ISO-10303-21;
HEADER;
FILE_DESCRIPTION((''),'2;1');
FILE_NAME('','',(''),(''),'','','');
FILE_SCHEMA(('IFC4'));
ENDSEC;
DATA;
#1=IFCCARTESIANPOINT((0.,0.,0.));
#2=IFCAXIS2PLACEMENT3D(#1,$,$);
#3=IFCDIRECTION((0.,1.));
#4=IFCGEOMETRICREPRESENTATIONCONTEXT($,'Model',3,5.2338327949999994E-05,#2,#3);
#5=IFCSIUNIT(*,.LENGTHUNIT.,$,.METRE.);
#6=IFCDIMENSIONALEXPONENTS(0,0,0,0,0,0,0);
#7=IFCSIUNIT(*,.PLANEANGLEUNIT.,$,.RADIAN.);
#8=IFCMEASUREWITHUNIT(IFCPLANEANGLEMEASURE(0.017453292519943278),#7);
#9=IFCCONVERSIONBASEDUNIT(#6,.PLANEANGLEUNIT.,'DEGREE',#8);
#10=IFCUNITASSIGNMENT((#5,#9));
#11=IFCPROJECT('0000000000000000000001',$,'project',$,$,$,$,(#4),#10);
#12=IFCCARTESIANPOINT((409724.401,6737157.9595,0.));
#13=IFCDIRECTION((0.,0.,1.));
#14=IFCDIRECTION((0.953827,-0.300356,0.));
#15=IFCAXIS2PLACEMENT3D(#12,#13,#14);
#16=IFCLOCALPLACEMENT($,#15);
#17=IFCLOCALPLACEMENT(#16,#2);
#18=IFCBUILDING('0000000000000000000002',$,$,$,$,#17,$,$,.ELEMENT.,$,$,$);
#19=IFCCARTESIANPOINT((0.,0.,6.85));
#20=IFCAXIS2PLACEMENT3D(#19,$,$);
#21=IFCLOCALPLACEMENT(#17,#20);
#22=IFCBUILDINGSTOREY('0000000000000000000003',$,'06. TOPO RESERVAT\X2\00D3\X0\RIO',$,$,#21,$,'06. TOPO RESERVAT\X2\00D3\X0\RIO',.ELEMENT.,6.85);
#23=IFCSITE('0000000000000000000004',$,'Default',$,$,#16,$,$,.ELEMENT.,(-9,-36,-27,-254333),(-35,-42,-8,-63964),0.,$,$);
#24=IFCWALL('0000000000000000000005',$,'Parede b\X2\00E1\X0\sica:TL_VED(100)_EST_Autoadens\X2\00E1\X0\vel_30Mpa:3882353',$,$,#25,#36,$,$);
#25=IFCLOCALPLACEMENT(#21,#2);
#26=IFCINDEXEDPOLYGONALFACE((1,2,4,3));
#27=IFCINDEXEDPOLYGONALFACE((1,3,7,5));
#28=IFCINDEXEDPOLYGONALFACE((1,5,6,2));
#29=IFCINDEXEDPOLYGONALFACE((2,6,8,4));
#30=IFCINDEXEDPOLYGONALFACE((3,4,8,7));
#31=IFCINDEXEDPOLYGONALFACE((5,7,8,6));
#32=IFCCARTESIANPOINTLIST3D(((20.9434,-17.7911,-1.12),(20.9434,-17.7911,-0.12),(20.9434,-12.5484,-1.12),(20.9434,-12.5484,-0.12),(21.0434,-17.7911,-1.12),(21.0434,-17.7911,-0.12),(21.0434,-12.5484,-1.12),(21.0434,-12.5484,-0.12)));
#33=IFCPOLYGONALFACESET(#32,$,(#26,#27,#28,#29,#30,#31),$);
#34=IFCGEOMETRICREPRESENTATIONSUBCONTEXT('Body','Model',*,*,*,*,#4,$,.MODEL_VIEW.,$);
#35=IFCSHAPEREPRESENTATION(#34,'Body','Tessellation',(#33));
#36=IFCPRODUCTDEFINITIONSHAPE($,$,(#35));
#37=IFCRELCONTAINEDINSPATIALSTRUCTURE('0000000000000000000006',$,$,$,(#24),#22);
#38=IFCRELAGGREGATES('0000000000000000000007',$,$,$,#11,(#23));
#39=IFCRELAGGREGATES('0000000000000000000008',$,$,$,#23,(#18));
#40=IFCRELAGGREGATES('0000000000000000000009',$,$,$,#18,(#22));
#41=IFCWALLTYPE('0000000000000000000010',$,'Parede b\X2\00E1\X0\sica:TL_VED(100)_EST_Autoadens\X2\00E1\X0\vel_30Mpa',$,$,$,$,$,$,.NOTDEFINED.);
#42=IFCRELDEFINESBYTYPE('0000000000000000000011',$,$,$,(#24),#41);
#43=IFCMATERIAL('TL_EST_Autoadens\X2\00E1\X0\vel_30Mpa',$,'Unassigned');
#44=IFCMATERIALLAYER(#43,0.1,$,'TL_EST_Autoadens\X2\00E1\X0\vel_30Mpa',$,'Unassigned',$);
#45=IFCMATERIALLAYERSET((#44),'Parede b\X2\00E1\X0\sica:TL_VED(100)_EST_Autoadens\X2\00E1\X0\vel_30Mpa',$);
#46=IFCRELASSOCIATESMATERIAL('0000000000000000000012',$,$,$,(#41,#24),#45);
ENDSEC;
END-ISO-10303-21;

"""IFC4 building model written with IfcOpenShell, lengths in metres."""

from ifc_helpers import new_model, entity, si_unit, converted_unit, direction, frame, frame_2d, origin, place, context, subcontext, project, spatial, rectangle, extrude, material, layer, layer_set, layer_usage, type_object, element, save


model = new_model("IFC4")

# Units and contexts
model_context = context("Model", 3, precision=5.2338327949999994e-05, world=origin(), true_north=direction((0.0, 1.0)))
body_context = subcontext(model_context, "Body", "Model", "MODEL_VIEW")
ifc_project = project(units=[si_unit("LENGTHUNIT", "METRE"), converted_unit("PLANEANGLEUNIT", "DEGREE", entity("IfcPlaneAngleMeasure", 0.017453292519943278), si_unit("PLANEANGLEUNIT", "RADIAN"), dimensions=[0, 0, 0, 0, 0, 0, 0])], contexts=[model_context])

# Site, building, storey
site_placement = place(None, frame((409724.401, 6737157.9595, 0.0), z_axis=(0.0, 0.0, 1.0), x_axis=(0.953827, -0.300356, 0.0)))
site = spatial("IfcSite", under=ifc_project, at=site_placement, Name="Default", CompositionType="ELEMENT", RefLatitude=(-9, -36, -27, -254333), RefLongitude=(-35, -42, -8, -63964), RefElevation=0.0)
building_placement = place(site_placement, origin())
building = spatial("IfcBuilding", under=site, at=building_placement, CompositionType="ELEMENT")
storey_placement = place(building_placement, frame((0.0, 0.0, 6.85)))
storey = spatial("IfcBuildingStorey", under=building, at=storey_placement, Name="06. TOPO RESERVATÓRIO", LongName="06. TOPO RESERVATÓRIO", CompositionType="ELEMENT", Elevation=6.85)

# Wall
ifc_material_1 = material(Name="TL_EST_Autoadensável_30Mpa", Category="Unassigned")
ifc_layer = layer(ifc_material_1, 0.1, Name="TL_EST_Autoadensável_30Mpa", Category="Unassigned")
ifc_layer_set = layer_set([ifc_layer], Name="Parede básica:TL_VED(100)_EST_Autoadensável_30Mpa")
ifc_layer_usage = layer_usage(ifc_layer_set, "AXIS2", "POSITIVE", -0.05)
wall_type = type_object("IfcWallType", Name="Parede básica:TL_VED(100)_EST_Autoadensável_30Mpa", PredefinedType="NOTDEFINED", material=ifc_layer_set)
wall_placement = place(storey_placement, frame((20.9934, -12.5484, -1.12), z_axis=(0.0, 0.0, 1.0), x_axis=(0.0, -1.0, 0.0)))
element("IfcWall", 1, at=wall_placement, inside=storey, type_object=wall_type, material=ifc_layer_usage, Name="Parede básica:TL_VED(100)_EST_Autoadensável_30Mpa:3882353", context=body_context, shape_type="SweptSolid", body=[
    extrude(rectangle(XDim=5.2427, YDim=0.1, at=frame_2d((2.6214, 0.0), x_axis=(-1.0, 0.0))), origin(), (0.0, 0.0, 1.0), 1.0),
])

save(model, "model.ifc")
